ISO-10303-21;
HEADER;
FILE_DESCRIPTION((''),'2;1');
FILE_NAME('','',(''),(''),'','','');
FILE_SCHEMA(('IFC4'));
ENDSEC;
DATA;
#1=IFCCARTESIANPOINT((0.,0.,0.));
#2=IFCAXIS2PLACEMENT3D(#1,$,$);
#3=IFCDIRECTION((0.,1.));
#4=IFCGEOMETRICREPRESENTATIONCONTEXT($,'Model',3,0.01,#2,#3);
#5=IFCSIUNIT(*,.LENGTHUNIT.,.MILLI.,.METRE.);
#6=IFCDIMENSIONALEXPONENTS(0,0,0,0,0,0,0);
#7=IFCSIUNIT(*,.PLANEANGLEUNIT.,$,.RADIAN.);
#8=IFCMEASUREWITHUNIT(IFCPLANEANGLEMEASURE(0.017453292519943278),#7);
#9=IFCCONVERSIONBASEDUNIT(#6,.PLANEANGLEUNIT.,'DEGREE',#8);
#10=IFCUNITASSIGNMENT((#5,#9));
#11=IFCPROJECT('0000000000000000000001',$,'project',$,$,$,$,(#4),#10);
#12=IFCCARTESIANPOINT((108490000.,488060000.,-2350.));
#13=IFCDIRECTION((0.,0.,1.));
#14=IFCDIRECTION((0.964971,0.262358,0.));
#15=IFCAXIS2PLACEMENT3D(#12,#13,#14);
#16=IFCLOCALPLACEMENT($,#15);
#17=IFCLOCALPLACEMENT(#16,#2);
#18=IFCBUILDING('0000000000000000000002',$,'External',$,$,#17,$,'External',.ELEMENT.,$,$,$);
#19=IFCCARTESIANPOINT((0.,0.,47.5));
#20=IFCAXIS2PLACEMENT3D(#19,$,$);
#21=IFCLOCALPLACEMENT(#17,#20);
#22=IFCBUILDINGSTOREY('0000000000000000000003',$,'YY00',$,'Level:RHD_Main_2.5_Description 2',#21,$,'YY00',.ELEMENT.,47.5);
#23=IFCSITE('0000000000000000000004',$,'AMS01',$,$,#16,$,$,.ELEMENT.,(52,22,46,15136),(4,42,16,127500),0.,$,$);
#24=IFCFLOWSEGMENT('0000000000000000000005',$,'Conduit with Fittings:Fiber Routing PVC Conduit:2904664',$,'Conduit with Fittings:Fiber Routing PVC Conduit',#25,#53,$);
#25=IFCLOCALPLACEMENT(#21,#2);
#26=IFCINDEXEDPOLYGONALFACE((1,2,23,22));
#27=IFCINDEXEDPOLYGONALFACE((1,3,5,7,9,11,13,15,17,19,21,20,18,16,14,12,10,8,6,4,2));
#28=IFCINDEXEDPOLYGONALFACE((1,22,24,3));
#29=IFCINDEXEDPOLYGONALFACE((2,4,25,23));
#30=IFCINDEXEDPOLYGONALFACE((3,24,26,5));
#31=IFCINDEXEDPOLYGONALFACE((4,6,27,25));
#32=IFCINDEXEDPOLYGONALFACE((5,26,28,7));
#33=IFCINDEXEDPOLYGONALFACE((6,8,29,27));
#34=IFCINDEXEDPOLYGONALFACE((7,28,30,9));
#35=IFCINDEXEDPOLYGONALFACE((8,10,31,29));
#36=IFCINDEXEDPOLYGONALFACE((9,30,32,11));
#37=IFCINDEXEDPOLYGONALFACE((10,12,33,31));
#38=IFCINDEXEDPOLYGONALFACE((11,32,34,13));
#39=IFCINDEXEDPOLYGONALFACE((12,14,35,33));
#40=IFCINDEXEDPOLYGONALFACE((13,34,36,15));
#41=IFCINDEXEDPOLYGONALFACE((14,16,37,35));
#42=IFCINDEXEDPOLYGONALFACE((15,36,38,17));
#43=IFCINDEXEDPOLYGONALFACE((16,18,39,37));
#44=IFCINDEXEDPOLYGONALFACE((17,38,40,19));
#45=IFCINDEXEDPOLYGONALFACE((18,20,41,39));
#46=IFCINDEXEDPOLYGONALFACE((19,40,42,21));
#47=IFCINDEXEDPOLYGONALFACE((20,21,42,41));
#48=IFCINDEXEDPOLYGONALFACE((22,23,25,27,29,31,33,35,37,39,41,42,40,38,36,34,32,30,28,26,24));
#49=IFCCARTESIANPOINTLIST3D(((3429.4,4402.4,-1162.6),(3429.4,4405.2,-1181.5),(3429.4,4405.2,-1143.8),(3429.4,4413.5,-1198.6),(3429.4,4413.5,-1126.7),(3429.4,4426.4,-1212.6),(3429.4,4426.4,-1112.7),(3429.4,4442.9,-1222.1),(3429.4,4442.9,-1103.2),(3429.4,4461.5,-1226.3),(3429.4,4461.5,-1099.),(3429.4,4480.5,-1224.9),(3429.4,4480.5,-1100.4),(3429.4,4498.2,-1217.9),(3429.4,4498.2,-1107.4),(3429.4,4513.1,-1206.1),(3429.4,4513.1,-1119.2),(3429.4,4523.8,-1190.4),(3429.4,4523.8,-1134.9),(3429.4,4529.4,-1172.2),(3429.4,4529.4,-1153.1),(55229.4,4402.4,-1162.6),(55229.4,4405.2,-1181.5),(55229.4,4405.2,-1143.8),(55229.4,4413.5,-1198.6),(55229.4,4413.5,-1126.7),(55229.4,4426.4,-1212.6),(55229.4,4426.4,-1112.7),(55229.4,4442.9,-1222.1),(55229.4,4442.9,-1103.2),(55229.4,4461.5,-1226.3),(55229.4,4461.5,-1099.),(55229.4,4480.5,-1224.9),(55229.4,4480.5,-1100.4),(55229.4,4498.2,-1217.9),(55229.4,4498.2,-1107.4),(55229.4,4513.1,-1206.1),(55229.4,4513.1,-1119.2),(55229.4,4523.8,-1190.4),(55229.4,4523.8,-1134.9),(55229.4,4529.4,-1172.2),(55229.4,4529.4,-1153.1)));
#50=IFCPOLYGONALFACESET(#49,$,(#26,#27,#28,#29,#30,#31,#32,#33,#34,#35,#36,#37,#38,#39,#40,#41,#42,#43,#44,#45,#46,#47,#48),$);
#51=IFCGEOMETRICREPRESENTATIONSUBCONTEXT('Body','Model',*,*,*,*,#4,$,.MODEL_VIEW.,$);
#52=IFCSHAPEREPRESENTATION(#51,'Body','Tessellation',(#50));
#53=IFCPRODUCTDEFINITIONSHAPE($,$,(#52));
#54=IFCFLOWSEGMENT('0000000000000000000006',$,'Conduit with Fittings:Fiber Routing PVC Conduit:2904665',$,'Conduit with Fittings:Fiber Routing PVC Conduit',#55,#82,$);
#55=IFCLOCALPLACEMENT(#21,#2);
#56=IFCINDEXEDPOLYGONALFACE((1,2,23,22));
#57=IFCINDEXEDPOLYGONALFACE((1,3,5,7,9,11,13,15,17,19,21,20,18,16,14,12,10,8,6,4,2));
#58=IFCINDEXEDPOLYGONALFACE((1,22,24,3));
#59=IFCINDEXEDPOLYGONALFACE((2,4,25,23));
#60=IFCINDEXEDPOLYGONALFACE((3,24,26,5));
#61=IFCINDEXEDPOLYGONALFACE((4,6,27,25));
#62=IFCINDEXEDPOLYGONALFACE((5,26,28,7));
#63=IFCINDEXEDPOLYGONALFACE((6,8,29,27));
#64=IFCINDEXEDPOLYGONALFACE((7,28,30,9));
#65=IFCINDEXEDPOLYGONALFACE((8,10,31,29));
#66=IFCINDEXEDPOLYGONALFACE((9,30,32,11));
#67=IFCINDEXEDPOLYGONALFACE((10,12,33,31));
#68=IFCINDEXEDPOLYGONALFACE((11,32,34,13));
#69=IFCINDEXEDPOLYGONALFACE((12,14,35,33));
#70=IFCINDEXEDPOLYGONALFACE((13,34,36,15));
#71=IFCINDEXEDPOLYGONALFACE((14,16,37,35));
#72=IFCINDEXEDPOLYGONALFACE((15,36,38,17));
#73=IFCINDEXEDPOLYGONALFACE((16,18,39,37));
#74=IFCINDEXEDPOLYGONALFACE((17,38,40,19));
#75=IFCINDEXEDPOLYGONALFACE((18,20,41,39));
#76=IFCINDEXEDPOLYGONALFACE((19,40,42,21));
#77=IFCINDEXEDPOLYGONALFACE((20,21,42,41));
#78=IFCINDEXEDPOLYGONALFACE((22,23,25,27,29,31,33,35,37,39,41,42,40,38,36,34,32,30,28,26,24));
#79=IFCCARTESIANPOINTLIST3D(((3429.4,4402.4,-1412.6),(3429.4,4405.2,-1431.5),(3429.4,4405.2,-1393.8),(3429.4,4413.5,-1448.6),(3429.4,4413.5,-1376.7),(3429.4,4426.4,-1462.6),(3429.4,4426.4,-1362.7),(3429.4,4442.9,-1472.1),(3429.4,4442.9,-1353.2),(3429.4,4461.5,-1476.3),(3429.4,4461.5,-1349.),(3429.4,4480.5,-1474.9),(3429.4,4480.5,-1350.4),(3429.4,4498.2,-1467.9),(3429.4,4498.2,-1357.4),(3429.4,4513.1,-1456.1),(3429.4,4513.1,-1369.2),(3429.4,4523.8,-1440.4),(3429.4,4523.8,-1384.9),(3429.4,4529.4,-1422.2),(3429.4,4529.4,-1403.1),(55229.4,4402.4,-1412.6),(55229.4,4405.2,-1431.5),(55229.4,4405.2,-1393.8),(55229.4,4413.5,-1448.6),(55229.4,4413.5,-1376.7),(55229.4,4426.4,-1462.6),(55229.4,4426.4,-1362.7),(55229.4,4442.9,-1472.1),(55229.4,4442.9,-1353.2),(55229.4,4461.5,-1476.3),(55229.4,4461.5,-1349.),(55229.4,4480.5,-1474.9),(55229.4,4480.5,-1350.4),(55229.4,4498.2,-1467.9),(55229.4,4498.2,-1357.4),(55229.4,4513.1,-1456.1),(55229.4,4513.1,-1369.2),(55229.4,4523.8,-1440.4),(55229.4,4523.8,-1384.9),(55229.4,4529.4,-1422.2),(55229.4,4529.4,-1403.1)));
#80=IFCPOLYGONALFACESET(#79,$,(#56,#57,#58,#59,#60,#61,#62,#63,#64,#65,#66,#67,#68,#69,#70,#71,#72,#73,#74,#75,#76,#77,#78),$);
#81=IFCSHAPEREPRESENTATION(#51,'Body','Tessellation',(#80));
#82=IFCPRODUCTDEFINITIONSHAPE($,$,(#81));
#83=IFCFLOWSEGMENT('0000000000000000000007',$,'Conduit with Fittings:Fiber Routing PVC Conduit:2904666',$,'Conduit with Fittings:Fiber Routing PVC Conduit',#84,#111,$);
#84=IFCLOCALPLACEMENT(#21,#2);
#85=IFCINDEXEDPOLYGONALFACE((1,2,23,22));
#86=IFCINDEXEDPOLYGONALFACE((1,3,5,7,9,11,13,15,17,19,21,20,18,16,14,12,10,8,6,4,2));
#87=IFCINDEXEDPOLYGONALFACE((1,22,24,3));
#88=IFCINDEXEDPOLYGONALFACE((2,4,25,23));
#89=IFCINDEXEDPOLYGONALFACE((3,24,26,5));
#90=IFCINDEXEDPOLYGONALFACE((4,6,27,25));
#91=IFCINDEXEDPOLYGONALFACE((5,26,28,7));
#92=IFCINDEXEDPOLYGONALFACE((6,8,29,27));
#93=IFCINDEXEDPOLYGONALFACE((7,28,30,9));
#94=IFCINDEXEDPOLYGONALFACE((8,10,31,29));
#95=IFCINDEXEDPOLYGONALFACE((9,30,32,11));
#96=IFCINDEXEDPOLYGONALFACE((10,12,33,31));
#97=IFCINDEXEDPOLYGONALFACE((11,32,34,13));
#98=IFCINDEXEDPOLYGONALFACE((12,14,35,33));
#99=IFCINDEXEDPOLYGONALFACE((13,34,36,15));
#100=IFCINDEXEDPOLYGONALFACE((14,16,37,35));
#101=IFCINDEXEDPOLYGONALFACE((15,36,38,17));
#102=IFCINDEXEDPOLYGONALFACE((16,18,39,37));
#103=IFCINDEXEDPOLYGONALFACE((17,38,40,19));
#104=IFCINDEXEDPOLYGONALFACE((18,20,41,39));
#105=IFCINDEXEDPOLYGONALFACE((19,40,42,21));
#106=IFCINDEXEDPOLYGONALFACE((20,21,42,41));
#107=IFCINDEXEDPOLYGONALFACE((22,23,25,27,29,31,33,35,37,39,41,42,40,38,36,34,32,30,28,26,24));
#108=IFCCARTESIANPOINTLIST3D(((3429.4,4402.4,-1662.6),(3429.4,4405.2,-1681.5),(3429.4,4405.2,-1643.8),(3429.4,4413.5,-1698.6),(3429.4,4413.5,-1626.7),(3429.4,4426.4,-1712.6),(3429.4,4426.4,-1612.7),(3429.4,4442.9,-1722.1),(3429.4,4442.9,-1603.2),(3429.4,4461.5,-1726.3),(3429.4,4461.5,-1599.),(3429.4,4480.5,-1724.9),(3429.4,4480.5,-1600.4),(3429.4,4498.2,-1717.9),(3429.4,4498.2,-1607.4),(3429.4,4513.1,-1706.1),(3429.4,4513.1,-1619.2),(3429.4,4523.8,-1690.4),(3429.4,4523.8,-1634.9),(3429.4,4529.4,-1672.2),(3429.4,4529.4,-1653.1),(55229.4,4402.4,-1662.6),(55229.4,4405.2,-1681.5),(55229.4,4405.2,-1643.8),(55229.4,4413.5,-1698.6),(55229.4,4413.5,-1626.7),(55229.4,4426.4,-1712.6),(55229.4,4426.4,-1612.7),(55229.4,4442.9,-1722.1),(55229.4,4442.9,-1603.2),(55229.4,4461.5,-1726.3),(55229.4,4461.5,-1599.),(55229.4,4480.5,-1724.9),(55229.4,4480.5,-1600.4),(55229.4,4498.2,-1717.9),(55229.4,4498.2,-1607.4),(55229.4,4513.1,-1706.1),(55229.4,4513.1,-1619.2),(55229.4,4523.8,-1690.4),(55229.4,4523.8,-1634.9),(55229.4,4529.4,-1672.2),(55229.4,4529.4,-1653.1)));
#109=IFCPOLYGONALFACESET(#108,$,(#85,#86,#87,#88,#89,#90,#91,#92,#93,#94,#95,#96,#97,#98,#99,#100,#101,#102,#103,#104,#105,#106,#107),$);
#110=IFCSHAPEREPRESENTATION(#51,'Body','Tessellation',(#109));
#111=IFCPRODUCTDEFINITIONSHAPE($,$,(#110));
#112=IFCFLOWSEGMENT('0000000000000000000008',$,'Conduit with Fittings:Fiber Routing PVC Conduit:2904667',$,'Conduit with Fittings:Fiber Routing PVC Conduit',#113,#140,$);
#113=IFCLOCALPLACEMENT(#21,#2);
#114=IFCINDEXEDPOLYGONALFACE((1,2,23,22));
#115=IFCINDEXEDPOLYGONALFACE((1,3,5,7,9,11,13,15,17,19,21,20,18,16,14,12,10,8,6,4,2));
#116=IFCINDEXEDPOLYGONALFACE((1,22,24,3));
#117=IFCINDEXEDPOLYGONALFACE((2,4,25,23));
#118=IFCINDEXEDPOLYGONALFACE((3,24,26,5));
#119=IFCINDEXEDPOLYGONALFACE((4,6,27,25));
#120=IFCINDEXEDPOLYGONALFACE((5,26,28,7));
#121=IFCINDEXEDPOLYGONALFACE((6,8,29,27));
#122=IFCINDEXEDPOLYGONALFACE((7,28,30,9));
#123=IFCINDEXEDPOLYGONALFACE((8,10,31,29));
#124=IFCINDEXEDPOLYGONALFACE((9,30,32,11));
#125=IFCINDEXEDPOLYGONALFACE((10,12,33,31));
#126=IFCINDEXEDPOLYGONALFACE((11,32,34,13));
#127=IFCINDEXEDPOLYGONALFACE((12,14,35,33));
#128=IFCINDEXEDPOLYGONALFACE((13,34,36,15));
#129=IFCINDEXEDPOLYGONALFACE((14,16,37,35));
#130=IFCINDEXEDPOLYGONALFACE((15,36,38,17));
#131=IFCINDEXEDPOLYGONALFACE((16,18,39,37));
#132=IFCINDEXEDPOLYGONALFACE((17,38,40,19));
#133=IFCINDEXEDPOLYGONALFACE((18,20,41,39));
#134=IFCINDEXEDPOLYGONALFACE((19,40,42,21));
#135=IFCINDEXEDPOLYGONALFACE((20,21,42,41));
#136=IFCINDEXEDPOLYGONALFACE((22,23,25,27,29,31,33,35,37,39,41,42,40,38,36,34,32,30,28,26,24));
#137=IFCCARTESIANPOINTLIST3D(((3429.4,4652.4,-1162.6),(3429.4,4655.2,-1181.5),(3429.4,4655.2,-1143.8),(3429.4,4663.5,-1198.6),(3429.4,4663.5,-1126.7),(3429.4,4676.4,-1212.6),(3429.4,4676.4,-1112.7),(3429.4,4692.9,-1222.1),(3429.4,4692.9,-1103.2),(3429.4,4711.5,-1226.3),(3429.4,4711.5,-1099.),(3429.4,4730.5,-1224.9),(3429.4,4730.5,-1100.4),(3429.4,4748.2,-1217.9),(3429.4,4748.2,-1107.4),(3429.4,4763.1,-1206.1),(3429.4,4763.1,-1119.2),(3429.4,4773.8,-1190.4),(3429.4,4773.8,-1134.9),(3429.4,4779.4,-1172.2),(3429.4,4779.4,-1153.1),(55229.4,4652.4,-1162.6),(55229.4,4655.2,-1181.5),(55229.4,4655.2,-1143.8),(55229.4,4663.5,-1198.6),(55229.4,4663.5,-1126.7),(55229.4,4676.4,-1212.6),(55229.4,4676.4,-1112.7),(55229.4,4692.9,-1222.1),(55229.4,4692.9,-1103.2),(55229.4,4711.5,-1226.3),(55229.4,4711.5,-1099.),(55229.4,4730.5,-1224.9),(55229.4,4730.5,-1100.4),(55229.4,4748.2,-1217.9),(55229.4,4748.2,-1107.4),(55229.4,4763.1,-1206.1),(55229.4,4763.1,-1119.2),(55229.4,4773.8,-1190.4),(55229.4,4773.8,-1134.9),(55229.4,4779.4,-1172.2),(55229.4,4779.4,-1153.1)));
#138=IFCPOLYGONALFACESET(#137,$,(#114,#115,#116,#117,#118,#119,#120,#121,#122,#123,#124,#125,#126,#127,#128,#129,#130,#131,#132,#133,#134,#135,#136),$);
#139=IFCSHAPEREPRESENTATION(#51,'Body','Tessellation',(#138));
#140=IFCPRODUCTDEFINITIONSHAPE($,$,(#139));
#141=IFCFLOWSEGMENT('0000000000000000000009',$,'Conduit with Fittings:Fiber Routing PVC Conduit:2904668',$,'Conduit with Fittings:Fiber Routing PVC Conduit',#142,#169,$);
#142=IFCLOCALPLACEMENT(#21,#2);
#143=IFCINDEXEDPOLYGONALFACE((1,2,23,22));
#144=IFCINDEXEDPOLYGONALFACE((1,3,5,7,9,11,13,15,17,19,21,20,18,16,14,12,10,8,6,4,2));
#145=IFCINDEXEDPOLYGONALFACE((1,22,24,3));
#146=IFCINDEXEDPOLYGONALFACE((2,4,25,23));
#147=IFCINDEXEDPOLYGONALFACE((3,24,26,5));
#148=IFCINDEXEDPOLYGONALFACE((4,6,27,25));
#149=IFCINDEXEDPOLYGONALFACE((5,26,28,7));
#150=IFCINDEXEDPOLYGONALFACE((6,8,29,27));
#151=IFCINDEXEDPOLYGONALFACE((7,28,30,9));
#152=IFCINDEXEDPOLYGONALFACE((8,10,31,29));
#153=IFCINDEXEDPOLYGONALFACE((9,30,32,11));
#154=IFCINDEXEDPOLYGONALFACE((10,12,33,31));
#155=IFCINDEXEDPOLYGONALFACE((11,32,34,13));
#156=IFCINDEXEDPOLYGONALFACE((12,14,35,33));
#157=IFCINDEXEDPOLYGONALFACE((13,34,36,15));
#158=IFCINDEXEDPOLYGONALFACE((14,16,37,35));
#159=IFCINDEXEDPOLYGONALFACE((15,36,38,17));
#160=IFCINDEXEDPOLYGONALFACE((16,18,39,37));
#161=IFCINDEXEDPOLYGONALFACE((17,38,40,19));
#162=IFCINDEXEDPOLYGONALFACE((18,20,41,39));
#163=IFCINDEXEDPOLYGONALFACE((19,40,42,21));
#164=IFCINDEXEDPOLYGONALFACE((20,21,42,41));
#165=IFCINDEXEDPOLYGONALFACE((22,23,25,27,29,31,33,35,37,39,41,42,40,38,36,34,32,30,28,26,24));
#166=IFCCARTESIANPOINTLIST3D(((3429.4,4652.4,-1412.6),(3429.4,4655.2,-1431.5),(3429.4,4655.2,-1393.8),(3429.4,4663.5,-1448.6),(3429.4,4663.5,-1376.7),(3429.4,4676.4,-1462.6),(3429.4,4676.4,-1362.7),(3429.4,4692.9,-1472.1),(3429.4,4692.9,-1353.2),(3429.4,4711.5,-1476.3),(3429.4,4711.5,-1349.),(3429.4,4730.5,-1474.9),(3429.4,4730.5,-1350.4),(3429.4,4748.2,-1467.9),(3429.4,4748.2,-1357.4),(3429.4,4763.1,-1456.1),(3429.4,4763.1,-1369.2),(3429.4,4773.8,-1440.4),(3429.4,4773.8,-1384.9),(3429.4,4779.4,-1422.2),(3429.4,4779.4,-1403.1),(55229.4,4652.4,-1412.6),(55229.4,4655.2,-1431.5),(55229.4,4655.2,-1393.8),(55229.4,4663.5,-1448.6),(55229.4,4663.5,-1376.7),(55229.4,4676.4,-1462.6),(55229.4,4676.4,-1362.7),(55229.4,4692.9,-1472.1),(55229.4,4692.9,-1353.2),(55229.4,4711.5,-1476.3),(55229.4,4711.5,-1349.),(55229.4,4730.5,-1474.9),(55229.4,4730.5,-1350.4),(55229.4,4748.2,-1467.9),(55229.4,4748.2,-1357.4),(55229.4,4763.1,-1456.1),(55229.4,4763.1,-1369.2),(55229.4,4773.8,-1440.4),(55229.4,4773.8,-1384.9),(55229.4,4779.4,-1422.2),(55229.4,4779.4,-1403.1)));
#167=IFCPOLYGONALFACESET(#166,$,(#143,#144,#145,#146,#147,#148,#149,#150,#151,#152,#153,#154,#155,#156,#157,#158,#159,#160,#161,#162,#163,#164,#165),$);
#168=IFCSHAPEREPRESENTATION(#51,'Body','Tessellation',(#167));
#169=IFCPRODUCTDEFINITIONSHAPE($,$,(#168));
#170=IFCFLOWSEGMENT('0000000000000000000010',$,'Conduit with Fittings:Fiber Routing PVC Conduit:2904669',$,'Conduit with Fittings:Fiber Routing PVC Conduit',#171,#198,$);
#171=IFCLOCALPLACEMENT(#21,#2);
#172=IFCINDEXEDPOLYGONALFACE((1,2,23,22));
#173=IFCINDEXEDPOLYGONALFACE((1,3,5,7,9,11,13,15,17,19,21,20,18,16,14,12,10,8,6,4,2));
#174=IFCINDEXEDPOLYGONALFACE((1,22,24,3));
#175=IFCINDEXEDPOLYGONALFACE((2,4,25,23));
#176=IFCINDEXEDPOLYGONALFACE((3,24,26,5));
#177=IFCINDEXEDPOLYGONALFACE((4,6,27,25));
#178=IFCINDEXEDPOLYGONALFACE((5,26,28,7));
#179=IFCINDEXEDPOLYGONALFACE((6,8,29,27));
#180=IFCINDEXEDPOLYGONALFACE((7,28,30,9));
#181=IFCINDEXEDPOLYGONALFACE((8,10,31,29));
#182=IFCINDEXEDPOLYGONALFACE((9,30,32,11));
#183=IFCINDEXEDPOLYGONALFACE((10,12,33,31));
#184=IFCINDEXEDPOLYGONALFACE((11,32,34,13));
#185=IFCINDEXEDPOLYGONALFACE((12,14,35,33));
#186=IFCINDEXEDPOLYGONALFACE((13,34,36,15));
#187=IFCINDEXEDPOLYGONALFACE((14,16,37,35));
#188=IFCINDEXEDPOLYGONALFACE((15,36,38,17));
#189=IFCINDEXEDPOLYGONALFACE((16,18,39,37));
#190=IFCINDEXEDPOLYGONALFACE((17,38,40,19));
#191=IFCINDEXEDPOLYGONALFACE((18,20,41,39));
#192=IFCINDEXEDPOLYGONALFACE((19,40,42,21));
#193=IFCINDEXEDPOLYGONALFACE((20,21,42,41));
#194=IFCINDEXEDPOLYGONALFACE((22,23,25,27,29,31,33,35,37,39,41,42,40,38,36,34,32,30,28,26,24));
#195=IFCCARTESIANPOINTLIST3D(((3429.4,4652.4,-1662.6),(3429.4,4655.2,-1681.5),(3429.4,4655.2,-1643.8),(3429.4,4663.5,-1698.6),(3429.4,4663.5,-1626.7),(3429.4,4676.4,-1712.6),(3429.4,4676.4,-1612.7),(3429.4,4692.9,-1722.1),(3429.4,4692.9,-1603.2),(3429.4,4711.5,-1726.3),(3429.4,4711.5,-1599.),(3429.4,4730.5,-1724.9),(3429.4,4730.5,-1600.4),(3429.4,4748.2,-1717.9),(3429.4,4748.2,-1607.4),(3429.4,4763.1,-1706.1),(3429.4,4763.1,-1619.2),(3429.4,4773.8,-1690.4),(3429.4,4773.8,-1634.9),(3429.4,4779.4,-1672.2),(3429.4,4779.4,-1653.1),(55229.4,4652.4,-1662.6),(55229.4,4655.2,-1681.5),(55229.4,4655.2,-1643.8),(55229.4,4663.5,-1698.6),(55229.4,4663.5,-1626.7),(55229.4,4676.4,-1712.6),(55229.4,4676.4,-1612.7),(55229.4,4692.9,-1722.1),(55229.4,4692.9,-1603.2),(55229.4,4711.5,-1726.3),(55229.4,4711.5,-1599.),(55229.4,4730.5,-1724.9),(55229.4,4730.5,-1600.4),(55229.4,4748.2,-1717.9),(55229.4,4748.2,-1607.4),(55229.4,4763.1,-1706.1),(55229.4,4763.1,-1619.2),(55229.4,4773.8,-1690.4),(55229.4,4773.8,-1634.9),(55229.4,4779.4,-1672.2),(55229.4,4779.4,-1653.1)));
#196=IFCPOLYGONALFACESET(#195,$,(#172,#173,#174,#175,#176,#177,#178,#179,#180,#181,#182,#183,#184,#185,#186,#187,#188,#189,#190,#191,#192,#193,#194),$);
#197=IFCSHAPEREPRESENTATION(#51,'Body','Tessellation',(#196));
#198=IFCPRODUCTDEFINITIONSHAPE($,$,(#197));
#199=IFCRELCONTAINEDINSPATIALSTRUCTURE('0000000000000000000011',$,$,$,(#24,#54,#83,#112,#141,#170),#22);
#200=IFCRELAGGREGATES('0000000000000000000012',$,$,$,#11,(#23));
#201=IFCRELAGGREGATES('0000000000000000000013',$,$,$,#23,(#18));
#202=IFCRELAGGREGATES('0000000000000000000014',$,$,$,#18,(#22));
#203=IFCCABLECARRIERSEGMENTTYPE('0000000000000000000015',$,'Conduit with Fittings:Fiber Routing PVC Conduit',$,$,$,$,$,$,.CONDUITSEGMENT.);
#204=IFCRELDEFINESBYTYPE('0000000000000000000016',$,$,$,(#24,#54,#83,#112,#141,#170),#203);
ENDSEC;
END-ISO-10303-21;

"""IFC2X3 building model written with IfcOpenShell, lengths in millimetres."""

from ifc_helpers import new_model, entity, si_unit, converted_unit, direction, frame, frame_2d, origin, origin_2d_with_axis, place, context, subcontext, project, spatial, circle, extrude, type_object, element, save


model = new_model("IFC2X3")

# Units and contexts
model_context = context("Model", 3, precision=0.01, world=origin(), true_north=direction((0.0, 1.0)))
body_context = subcontext(model_context, "Body", "Model", "MODEL_VIEW")
ifc_project = project(units=[si_unit("LENGTHUNIT", "METRE", prefix="MILLI"), converted_unit("PLANEANGLEUNIT", "DEGREE", entity("IfcPlaneAngleMeasure", 0.017453292519943278), si_unit("PLANEANGLEUNIT", "RADIAN"), dimensions=[0, 0, 0, 0, 0, 0, 0])], contexts=[model_context])

# Site, building, storey
site_placement = place(None, frame((108490000.0, 488060000.0, -2350.0), z_axis=(0.0, 0.0, 1.0), x_axis=(0.964971, 0.262358, 0.0)))
site = spatial("IfcSite", under=ifc_project, at=site_placement, Name="AMS01", CompositionType="ELEMENT", RefLatitude=(52, 22, 46, 15136), RefLongitude=(4, 42, 16, 127500), RefElevation=0.0)
building_placement = place(site_placement, origin())
building = spatial("IfcBuilding", under=site, at=building_placement, Name="External", LongName="External", CompositionType="ELEMENT")
storey_placement = place(building_placement, frame((0.0, 0.0, 47.5)))
storey = spatial("IfcBuildingStorey", under=building, at=storey_placement, Name="YY00", ObjectType="Level:RHD_Main_2.5_Description 2", LongName="YY00", CompositionType="ELEMENT", Elevation=47.5)

# Flow segments
cable_carrier_segment_type = type_object("IfcCableCarrierSegmentType", Name="Conduit with Fittings:Fiber Routing PVC Conduit", PredefinedType="CONDUITSEGMENT")
flow_segment_1_placement = place(storey_placement, origin())
element("IfcFlowSegment", 1, at=flow_segment_1_placement, inside=storey, type_object=cable_carrier_segment_type, Name="Conduit with Fittings:Fiber Routing PVC Conduit:2904664", ObjectType="Conduit with Fittings:Fiber Routing PVC Conduit", context=body_context, shape_type="SweptSolid", body=[
    extrude(circle(Radius=63.9, at=origin_2d_with_axis()), frame((3429.4, 4466.3, -1162.6), z_axis=(1.0, 0.0, 0.0), x_axis=(0.0, -1.0, 0.0)), (0.0, 0.0, 1.0), 51800.0),
])
flow_segment_2_placement = place(storey_placement, origin())
element("IfcFlowSegment", 2, at=flow_segment_2_placement, inside=storey, type_object=cable_carrier_segment_type, Name="Conduit with Fittings:Fiber Routing PVC Conduit:2904665", ObjectType="Conduit with Fittings:Fiber Routing PVC Conduit", context=body_context, shape_type="SweptSolid", body=[
    extrude(circle(Radius=63.9, at=origin_2d_with_axis()), frame((3429.4, 4466.3, -1412.6), z_axis=(1.0, 0.0, 0.0), x_axis=(0.0, -1.0, 0.0)), (0.0, 0.0, 1.0), 51800.0),
])
flow_segment_3_placement = place(storey_placement, origin())
element("IfcFlowSegment", 3, at=flow_segment_3_placement, inside=storey, type_object=cable_carrier_segment_type, Name="Conduit with Fittings:Fiber Routing PVC Conduit:2904666", ObjectType="Conduit with Fittings:Fiber Routing PVC Conduit", context=body_context, shape_type="SweptSolid", body=[
    extrude(circle(Radius=63.9, at=frame_2d((0.0, 0.0), x_axis=(1.0, 0.0))), frame((3429.4, 4466.3, -1662.6), z_axis=(1.0, 0.0, 0.0), x_axis=(0.0, -1.0, 0.0)), (0.0, 0.0, 1.0), 51800.0),
])
flow_segment_4_placement = place(storey_placement, origin())
element("IfcFlowSegment", 4, at=flow_segment_4_placement, inside=storey, type_object=cable_carrier_segment_type, Name="Conduit with Fittings:Fiber Routing PVC Conduit:2904667", ObjectType="Conduit with Fittings:Fiber Routing PVC Conduit", context=body_context, shape_type="SweptSolid", body=[
    extrude(circle(Radius=63.9, at=frame_2d((0.0, 0.0), x_axis=(1.0, 0.0))), frame((3429.4, 4716.3, -1162.6), z_axis=(1.0, 0.0, 0.0), x_axis=(0.0, -1.0, 0.0)), (0.0, 0.0, 1.0), 51800.0),
])
flow_segment_5_placement = place(storey_placement, origin())
element("IfcFlowSegment", 5, at=flow_segment_5_placement, inside=storey, type_object=cable_carrier_segment_type, Name="Conduit with Fittings:Fiber Routing PVC Conduit:2904668", ObjectType="Conduit with Fittings:Fiber Routing PVC Conduit", context=body_context, shape_type="SweptSolid", body=[
    extrude(circle(Radius=63.9, at=origin_2d_with_axis()), frame((3429.4, 4716.3, -1412.6), z_axis=(1.0, 0.0, 0.0), x_axis=(0.0, -1.0, 0.0)), (0.0, 0.0, 1.0), 51800.0),
])
flow_segment_6_placement = place(storey_placement, origin())
element("IfcFlowSegment", 6, at=flow_segment_6_placement, inside=storey, type_object=cable_carrier_segment_type, Name="Conduit with Fittings:Fiber Routing PVC Conduit:2904669", ObjectType="Conduit with Fittings:Fiber Routing PVC Conduit", context=body_context, shape_type="SweptSolid", body=[
    extrude(circle(Radius=63.9, at=origin_2d_with_axis()), frame((3429.4, 4716.3, -1662.6), z_axis=(1.0, 0.0, 0.0), x_axis=(0.0, -1.0, 0.0)), (0.0, 0.0, 1.0), 51800.0),
])

save(model, "model.ifc")
